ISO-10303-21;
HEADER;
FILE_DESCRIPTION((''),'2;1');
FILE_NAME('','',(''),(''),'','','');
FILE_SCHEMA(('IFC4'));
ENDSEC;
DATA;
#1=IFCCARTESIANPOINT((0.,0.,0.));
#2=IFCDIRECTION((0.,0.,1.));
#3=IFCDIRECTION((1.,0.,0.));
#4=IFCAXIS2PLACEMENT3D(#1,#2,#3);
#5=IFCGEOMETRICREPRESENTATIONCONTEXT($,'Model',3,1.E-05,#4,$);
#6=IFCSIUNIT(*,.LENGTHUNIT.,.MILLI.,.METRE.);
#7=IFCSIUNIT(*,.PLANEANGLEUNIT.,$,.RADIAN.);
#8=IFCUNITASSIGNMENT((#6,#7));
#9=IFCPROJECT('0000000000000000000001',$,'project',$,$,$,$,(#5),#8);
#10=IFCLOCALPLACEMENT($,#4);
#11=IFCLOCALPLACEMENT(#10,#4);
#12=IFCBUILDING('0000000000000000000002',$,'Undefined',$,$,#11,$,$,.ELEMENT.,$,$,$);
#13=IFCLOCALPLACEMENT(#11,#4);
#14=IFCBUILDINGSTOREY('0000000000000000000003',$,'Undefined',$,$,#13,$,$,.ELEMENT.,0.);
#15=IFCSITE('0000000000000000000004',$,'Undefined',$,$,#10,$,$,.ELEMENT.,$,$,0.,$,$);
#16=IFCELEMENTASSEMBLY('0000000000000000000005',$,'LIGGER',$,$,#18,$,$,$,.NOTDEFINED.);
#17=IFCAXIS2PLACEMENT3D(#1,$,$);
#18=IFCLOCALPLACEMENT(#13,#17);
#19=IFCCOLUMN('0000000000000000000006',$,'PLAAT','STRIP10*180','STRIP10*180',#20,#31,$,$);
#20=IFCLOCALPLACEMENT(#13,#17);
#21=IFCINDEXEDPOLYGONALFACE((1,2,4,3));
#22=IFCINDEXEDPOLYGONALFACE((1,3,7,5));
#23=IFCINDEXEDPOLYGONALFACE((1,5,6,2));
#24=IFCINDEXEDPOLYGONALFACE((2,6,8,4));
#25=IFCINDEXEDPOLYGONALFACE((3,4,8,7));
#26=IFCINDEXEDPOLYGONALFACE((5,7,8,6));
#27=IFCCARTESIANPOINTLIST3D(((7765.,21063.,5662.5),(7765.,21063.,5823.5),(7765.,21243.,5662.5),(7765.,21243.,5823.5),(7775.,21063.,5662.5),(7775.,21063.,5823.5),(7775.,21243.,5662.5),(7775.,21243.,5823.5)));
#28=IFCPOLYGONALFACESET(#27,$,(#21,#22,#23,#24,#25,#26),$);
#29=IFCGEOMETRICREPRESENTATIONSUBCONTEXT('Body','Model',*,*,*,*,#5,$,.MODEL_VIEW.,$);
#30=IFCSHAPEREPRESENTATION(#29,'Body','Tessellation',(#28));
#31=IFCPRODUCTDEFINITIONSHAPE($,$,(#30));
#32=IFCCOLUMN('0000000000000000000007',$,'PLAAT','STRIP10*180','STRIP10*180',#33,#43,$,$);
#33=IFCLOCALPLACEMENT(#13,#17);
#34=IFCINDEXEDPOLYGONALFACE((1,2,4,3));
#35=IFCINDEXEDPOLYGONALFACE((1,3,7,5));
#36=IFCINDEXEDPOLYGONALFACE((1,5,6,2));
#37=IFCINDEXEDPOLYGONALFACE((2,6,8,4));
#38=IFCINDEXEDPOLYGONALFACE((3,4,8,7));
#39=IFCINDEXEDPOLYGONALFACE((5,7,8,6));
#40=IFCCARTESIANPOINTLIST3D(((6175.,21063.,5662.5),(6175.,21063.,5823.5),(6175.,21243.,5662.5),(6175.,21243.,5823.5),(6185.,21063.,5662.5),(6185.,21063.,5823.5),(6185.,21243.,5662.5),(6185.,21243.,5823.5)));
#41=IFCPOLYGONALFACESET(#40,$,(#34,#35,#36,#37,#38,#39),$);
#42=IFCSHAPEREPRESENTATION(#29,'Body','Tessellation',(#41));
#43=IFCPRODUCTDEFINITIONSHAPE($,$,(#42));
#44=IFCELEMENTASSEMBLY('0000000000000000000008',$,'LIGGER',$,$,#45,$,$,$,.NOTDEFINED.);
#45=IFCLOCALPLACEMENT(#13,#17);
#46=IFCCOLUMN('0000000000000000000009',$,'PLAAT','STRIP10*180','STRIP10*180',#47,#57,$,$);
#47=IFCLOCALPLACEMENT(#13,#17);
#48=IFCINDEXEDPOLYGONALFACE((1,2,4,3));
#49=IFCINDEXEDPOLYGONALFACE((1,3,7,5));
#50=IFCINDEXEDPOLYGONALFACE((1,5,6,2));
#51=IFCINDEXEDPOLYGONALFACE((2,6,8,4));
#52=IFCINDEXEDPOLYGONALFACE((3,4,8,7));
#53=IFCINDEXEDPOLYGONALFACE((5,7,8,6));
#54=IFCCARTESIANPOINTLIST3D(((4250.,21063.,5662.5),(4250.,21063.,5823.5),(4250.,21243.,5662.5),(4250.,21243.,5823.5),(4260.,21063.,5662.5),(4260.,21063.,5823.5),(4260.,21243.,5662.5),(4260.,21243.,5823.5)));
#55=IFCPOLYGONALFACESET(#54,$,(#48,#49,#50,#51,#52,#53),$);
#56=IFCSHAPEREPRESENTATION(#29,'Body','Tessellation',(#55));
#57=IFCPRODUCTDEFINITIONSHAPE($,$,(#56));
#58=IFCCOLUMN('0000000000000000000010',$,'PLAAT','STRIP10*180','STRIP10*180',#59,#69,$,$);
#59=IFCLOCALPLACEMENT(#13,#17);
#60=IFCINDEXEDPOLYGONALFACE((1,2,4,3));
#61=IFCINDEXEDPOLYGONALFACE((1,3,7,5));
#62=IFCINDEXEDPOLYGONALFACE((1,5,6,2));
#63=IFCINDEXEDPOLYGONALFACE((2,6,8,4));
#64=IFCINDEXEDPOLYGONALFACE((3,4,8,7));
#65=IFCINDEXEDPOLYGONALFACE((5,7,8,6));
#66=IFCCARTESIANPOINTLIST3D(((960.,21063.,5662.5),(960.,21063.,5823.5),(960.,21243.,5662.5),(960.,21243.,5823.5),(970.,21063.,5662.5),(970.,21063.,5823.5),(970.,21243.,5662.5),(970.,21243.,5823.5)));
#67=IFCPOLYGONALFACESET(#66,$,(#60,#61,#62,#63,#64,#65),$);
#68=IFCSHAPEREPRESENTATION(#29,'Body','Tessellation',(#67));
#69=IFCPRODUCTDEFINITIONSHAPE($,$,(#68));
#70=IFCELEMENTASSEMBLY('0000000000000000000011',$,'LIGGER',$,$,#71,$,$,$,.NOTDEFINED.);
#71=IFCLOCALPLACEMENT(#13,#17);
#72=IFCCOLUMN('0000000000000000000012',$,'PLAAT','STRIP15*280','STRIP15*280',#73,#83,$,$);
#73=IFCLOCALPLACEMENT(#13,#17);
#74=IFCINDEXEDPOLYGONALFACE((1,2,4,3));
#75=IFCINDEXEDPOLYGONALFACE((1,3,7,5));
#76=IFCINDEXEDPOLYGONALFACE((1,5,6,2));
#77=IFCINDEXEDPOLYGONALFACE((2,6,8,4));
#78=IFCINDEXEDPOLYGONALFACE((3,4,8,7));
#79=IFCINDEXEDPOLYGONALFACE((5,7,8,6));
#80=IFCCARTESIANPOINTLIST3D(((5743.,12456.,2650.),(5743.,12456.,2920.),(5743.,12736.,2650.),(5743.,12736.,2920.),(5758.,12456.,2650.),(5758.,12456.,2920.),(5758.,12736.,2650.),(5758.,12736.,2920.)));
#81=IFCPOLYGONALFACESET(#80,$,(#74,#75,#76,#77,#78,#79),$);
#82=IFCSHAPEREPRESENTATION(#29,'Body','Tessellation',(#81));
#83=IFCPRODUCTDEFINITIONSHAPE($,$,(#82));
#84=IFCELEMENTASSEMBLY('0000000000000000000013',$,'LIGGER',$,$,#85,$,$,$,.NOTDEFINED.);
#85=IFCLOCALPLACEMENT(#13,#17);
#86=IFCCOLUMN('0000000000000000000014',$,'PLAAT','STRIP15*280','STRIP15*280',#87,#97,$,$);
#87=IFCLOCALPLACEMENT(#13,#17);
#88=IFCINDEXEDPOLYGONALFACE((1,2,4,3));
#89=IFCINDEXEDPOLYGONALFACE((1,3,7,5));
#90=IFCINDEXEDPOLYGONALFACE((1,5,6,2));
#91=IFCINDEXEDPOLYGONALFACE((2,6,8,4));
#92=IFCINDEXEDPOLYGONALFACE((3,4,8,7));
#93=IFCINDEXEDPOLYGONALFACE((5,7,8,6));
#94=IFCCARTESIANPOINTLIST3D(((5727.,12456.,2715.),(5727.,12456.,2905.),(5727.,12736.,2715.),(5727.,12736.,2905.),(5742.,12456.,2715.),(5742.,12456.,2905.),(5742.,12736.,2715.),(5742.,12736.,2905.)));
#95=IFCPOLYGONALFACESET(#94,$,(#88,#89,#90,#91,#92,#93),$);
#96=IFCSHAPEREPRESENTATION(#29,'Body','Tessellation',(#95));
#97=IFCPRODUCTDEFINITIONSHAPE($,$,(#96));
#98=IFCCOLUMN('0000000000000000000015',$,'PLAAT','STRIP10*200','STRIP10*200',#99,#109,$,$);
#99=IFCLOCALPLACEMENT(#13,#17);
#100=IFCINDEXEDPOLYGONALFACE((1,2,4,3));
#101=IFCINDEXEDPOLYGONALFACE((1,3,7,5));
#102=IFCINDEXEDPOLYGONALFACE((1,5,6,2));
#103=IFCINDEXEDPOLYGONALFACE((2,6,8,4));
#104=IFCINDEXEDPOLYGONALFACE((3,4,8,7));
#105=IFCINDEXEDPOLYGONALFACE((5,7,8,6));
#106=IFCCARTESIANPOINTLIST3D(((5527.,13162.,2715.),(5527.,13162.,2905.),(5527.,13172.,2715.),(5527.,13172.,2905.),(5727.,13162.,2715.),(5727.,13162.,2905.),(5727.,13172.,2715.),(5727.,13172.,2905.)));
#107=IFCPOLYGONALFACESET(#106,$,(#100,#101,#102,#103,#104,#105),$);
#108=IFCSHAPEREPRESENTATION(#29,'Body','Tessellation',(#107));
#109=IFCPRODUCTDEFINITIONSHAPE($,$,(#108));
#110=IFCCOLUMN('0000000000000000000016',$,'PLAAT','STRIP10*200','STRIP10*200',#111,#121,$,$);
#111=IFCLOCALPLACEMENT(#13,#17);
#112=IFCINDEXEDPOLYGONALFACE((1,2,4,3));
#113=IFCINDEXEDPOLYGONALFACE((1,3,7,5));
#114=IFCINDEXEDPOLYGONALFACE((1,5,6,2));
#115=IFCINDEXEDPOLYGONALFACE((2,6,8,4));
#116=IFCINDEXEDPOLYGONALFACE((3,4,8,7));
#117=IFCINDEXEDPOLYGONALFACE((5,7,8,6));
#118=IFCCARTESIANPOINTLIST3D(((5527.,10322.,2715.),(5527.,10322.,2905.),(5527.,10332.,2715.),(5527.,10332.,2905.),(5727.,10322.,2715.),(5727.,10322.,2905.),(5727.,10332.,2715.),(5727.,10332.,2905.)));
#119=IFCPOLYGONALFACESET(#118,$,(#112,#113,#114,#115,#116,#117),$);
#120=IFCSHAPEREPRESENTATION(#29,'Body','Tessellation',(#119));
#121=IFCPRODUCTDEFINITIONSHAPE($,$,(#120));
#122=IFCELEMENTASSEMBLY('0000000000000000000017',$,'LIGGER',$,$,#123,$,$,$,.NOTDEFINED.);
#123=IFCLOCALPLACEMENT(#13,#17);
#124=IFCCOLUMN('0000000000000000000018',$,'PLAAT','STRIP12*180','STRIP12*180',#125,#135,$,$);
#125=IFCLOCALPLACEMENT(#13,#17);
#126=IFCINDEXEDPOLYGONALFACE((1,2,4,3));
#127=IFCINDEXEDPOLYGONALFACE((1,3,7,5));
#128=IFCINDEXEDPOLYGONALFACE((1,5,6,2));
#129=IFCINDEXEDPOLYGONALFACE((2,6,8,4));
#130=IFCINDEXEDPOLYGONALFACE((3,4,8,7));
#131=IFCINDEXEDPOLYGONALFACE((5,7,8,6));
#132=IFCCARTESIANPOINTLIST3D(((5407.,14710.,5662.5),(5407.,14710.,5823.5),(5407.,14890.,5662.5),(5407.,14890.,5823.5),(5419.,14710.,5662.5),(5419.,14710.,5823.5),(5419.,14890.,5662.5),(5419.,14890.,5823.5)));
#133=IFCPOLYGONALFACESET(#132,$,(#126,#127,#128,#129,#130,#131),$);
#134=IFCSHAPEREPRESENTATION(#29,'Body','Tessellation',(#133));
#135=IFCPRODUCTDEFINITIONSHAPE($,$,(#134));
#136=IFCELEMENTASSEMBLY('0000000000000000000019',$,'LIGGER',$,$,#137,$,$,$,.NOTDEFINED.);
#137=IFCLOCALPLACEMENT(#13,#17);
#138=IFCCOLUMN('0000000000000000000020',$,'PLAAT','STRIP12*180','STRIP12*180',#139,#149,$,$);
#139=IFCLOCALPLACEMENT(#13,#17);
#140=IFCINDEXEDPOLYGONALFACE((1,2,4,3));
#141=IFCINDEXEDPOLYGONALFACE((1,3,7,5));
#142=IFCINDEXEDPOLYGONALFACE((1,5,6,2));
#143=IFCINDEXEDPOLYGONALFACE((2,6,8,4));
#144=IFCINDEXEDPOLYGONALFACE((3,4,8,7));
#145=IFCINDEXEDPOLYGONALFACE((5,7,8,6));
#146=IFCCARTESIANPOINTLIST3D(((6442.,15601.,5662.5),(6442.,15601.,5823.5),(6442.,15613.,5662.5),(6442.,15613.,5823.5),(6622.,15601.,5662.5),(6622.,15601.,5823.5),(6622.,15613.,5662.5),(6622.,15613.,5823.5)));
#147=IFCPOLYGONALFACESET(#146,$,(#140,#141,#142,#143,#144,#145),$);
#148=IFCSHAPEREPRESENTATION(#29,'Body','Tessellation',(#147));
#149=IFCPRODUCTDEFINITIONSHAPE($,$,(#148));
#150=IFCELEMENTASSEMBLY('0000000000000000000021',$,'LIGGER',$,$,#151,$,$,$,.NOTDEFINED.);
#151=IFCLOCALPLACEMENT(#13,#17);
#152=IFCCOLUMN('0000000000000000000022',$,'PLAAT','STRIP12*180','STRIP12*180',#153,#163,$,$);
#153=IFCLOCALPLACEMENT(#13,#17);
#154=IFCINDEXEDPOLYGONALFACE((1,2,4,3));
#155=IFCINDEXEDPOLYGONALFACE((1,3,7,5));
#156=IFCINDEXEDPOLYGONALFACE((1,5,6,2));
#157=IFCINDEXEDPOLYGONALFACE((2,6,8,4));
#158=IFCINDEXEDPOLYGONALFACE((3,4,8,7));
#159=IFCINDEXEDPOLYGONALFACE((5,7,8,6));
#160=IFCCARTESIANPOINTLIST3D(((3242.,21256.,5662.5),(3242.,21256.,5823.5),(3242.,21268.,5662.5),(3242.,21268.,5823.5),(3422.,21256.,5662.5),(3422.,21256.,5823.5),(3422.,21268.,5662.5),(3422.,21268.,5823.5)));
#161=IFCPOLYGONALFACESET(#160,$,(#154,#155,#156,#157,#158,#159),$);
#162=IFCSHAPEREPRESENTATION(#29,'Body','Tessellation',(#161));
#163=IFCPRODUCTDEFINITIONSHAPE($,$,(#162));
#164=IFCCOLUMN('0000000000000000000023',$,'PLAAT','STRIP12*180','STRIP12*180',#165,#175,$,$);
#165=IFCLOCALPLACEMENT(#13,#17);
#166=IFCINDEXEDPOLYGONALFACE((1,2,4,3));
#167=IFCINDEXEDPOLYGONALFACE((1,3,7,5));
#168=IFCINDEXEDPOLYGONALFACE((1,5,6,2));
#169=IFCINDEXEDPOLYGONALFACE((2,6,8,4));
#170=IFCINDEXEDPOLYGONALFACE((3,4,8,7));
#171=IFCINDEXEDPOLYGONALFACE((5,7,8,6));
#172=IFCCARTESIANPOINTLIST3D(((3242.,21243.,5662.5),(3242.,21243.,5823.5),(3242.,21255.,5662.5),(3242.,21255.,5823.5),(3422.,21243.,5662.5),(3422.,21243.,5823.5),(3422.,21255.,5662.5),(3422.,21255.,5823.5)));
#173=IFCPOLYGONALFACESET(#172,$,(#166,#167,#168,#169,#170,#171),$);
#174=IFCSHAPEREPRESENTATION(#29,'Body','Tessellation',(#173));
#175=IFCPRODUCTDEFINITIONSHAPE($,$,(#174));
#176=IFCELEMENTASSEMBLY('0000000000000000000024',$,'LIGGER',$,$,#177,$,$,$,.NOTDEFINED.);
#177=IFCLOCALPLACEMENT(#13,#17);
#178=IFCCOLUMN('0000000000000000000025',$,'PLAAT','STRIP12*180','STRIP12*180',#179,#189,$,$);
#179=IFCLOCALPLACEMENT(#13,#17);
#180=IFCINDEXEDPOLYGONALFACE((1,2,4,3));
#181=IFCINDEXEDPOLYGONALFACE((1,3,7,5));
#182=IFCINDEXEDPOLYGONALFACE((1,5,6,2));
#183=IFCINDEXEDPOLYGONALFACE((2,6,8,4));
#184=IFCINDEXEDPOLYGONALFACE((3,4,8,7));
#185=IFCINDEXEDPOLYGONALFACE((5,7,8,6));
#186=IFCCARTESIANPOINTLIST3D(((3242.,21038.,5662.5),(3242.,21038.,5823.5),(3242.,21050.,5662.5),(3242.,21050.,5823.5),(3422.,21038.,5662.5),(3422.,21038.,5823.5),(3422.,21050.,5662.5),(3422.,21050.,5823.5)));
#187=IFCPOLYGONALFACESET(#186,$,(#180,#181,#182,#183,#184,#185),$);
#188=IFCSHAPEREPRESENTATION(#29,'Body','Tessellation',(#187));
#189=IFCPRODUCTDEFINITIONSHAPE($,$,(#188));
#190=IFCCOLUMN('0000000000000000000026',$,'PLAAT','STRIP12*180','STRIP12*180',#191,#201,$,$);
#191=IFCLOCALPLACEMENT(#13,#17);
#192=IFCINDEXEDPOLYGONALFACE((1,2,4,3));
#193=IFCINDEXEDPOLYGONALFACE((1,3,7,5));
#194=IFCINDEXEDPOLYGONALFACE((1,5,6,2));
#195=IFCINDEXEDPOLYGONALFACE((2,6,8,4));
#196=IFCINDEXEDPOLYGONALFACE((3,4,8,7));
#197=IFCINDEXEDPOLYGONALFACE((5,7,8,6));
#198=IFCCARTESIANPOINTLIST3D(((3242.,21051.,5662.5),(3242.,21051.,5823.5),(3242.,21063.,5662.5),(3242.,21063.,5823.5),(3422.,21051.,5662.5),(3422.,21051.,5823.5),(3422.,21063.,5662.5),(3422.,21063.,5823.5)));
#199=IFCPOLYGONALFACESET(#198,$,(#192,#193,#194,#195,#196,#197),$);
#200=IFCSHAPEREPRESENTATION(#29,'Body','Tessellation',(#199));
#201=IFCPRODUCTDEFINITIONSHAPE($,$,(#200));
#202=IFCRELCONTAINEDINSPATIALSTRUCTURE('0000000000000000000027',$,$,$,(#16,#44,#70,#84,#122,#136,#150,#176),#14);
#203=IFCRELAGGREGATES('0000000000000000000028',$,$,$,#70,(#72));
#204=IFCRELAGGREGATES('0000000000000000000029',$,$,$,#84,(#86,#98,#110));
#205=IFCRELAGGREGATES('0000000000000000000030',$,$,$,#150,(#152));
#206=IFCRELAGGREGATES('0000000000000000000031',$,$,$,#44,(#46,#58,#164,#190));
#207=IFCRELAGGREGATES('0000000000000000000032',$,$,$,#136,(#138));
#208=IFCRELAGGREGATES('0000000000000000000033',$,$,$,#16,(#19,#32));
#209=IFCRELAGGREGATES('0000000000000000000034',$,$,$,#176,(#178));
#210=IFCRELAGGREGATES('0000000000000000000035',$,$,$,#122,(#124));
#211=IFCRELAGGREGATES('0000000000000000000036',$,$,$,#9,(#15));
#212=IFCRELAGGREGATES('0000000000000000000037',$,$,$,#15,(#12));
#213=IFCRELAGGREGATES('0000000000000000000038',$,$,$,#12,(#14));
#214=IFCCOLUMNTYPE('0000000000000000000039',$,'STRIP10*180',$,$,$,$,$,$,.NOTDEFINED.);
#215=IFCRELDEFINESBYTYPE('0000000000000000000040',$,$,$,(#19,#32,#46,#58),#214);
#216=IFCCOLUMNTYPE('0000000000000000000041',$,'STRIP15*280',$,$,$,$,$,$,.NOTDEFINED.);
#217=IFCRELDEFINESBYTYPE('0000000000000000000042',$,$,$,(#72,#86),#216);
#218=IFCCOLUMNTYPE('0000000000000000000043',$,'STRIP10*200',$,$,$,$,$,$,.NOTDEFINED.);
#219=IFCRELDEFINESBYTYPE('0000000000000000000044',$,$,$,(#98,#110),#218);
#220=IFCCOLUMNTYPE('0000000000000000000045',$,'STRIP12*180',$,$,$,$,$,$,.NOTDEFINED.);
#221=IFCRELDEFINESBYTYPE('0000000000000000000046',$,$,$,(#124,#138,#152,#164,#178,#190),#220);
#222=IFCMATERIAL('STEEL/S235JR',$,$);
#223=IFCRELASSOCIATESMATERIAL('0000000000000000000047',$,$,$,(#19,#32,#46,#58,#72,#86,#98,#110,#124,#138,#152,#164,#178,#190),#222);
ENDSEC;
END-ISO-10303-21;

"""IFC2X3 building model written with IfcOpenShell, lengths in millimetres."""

from ifc_helpers import new_model, si_unit, frame, origin_with_axes, origin_2d_with_axis, place, context, subcontext, project, spatial, rectangle, extrude, material, type_object, element, aggregate, save


model = new_model("IFC2X3")

# Units and contexts
model_context = context("Model", 3, precision=1e-05, world=origin_with_axes())
body_context = subcontext(model_context, "Body", "Model", "MODEL_VIEW")
ifc_project = project(units=[si_unit("LENGTHUNIT", "METRE", prefix="MILLI"), si_unit("PLANEANGLEUNIT", "RADIAN")], contexts=[model_context])

# Site, building, storey
site_placement = place(None, origin_with_axes())
site = spatial("IfcSite", under=ifc_project, at=site_placement, Name="Undefined", CompositionType="ELEMENT", RefElevation=0.0)
building_placement = place(site_placement, origin_with_axes())
building = spatial("IfcBuilding", under=site, at=building_placement, Name="Undefined", CompositionType="ELEMENT")
storey_placement = place(building_placement, origin_with_axes())
storey = spatial("IfcBuildingStorey", under=building, at=storey_placement, Name="Undefined", CompositionType="ELEMENT", Elevation=0.0)

# Element assemblies, columns
assembly_1_placement = place(storey_placement, frame((7775.0, 21153.0, 5743.0), z_axis=(0.0, 0.0, 1.0), x_axis=(-1.0, 0.0, 0.0)))
assembly_1 = element("IfcElementAssembly", 1, at=assembly_1_placement, inside=storey, Name="LIGGER", PredefinedType="NOTDEFINED")
ifc_material = material(Name="STEEL/S235JR")
column_type_1 = type_object("IfcColumnType", Name="STRIP10*180", PredefinedType="NOTDEFINED")
column_1_placement = place(storey_placement, frame((7770.0, 21153.0, 5662.5), z_axis=(0.0, 0.0, 1.0), x_axis=(1.0, 0.0, 0.0)))
column_1 = element("IfcColumn", 2, at=column_1_placement, type_object=column_type_1, material=ifc_material, Name="PLAAT", Description="STRIP10*180", ObjectType="STRIP10*180", context=body_context, shape_type="SweptSolid", body=[
    extrude(rectangle(XDim=10.0, YDim=180.0, at=origin_2d_with_axis()), frame((0.0, 0.0, 161.0), z_axis=(0.0, 0.0, -1.0), x_axis=(-1.0, 0.0, 0.0)), (0.0, 0.0, 1.0), 161.0),
])
column_2_placement = place(storey_placement, frame((6180.0, 21153.0, 5662.5), z_axis=(0.0, 0.0, 1.0), x_axis=(1.0, 0.0, 0.0)))
column_2 = element("IfcColumn", 3, at=column_2_placement, type_object=column_type_1, material=ifc_material, Name="PLAAT", Description="STRIP10*180", ObjectType="STRIP10*180", context=body_context, shape_type="SweptSolid", body=[
    extrude(rectangle(XDim=10.0, YDim=180.0, at=origin_2d_with_axis()), frame((0.0, 0.0, 161.0), z_axis=(0.0, 0.0, -1.0), x_axis=(1.0, 0.0, 0.0)), (0.0, 0.0, 1.0), 161.0),
])
assembly_2_placement = place(storey_placement, frame((960.0, 21153.0, 5743.0), z_axis=(0.0, 0.0, 1.0), x_axis=(1.0, 0.0, 0.0)))
assembly_2 = element("IfcElementAssembly", 4, at=assembly_2_placement, inside=storey, Name="LIGGER", PredefinedType="NOTDEFINED")
column_3_placement = place(storey_placement, frame((4255.0, 21153.0, 5662.5), z_axis=(0.0, 0.0, 1.0), x_axis=(1.0, 0.0, 0.0)))
column_3 = element("IfcColumn", 5, at=column_3_placement, type_object=column_type_1, material=ifc_material, Name="PLAAT", Description="STRIP10*180", ObjectType="STRIP10*180", context=body_context, shape_type="SweptSolid", body=[
    extrude(rectangle(XDim=10.0, YDim=180.0, at=origin_2d_with_axis()), frame((0.0, 0.0, 161.0), z_axis=(0.0, 0.0, -1.0), x_axis=(-1.0, 0.0, 0.0)), (0.0, 0.0, 1.0), 161.0),
])
column_4_placement = place(storey_placement, frame((965.0, 21153.0, 5662.5), z_axis=(0.0, 0.0, 1.0), x_axis=(1.0, 0.0, 0.0)))
column_4 = element("IfcColumn", 6, at=column_4_placement, type_object=column_type_1, material=ifc_material, Name="PLAAT", Description="STRIP10*180", ObjectType="STRIP10*180", context=body_context, shape_type="SweptSolid", body=[
    extrude(rectangle(XDim=10.0, YDim=180.0, at=origin_2d_with_axis()), frame((0.0, 0.0, 161.0), z_axis=(0.0, 0.0, -1.0), x_axis=(1.0, 0.0, 0.0)), (0.0, 0.0, 1.0), 161.0),
])

# Element assembly, column
assembly_3_placement = place(storey_placement, frame((5727.0, 12596.0, 2785.0), z_axis=(0.0, 0.0, 1.0), x_axis=(1.0, 0.0, 0.0)))
assembly_3 = element("IfcElementAssembly", 7, at=assembly_3_placement, inside=storey, Name="LIGGER", PredefinedType="NOTDEFINED")
column_type_2 = type_object("IfcColumnType", Name="STRIP15*280", PredefinedType="NOTDEFINED")
column_5_placement = place(storey_placement, frame((5750.5, 12596.0, 2650.0), z_axis=(0.0, 0.0, 1.0), x_axis=(1.0, 0.0, 0.0)))
column_5 = element("IfcColumn", 8, at=column_5_placement, type_object=column_type_2, material=ifc_material, Name="PLAAT", Description="STRIP15*280", ObjectType="STRIP15*280", context=body_context, shape_type="SweptSolid", body=[
    extrude(rectangle(XDim=15.0, YDim=280.0, at=origin_2d_with_axis()), frame((0.0, 0.0, 270.0), z_axis=(0.0, 0.0, -1.0), x_axis=(1.0, 0.0, 0.0)), (0.0, 0.0, 1.0), 270.0),
])
aggregate(assembly_3, [column_5])

# Element assembly, columns
assembly_4_placement = place(storey_placement, frame((5627.0, 10322.0, 2810.0), z_axis=(0.0, 0.0, 1.0), x_axis=(0.0, 1.0, 0.0)))
assembly_4 = element("IfcElementAssembly", 9, at=assembly_4_placement, inside=storey, Name="LIGGER", PredefinedType="NOTDEFINED")
column_6_placement = place(storey_placement, frame((5734.5, 12596.0, 2715.0), z_axis=(0.0, 0.0, 1.0), x_axis=(1.0, 0.0, 0.0)))
column_6 = element("IfcColumn", 10, at=column_6_placement, type_object=column_type_2, material=ifc_material, Name="PLAAT", Description="STRIP15*280", ObjectType="STRIP15*280", context=body_context, shape_type="SweptSolid", body=[
    extrude(rectangle(XDim=15.0, YDim=280.0, at=origin_2d_with_axis()), frame((0.0, 0.0, 190.0), z_axis=(0.0, 0.0, -1.0), x_axis=(1.0, 0.0, 0.0)), (0.0, 0.0, 1.0), 190.0),
])
column_type_3 = type_object("IfcColumnType", Name="STRIP10*200", PredefinedType="NOTDEFINED")
column_7_placement = place(storey_placement, frame((5627.0, 13167.0, 2715.0), z_axis=(0.0, 0.0, 1.0), x_axis=(1.0, 0.0, 0.0)))
column_7 = element("IfcColumn", 11, at=column_7_placement, type_object=column_type_3, material=ifc_material, Name="PLAAT", Description="STRIP10*200", ObjectType="STRIP10*200", context=body_context, shape_type="SweptSolid", body=[
    extrude(rectangle(XDim=10.0, YDim=200.0, at=origin_2d_with_axis()), frame((0.0, 0.0, 190.0), z_axis=(0.0, 0.0, -1.0), x_axis=(0.0, -1.0, 0.0)), (0.0, 0.0, 1.0), 190.0),
])
column_8_placement = place(storey_placement, frame((5627.0, 10327.0, 2715.0), z_axis=(0.0, 0.0, 1.0), x_axis=(1.0, 0.0, 0.0)))
column_8 = element("IfcColumn", 12, at=column_8_placement, type_object=column_type_3, material=ifc_material, Name="PLAAT", Description="STRIP10*200", ObjectType="STRIP10*200", context=body_context, shape_type="SweptSolid", body=[
    extrude(rectangle(XDim=10.0, YDim=200.0, at=origin_2d_with_axis()), frame((0.0, 0.0, 190.0), z_axis=(0.0, 0.0, -1.0), x_axis=(0.0, 1.0, 0.0)), (0.0, 0.0, 1.0), 190.0),
])
aggregate(assembly_4, [column_6, column_7, column_8])

# Element assemblies, columns
assembly_5_placement = place(storey_placement, frame((810.1, 14800.0, 5743.0), z_axis=(0.0, 0.0, 1.0), x_axis=(1.0, 0.0, 0.0)))
assembly_5 = element("IfcElementAssembly", 13, at=assembly_5_placement, inside=storey, Name="LIGGER", PredefinedType="NOTDEFINED")
column_type_4 = type_object("IfcColumnType", Name="STRIP12*180", PredefinedType="NOTDEFINED")
column_9_placement = place(storey_placement, frame((5413.0, 14800.0, 5662.5), z_axis=(0.0, 0.0, 1.0), x_axis=(1.0, 0.0, 0.0)))
column_9 = element("IfcColumn", 14, at=column_9_placement, type_object=column_type_4, material=ifc_material, Name="PLAAT", Description="STRIP12*180", ObjectType="STRIP12*180", context=body_context, shape_type="SweptSolid", body=[
    extrude(rectangle(XDim=12.0, YDim=180.0, at=origin_2d_with_axis()), frame((0.0, 0.0, 161.0), z_axis=(0.0, 0.0, -1.0), x_axis=(-1.0, 0.0, 0.0)), (0.0, 0.0, 1.0), 161.0),
])
assembly_6_placement = place(storey_placement, frame((6532.0, 21062.1, 5743.0), z_axis=(0.0, 0.0, 1.0), x_axis=(0.0, -1.0, 0.0)))
assembly_6 = element("IfcElementAssembly", 15, at=assembly_6_placement, inside=storey, Name="LIGGER", PredefinedType="NOTDEFINED")
column_10_placement = place(storey_placement, frame((6532.0, 15607.0, 5662.5), z_axis=(0.0, 0.0, 1.0), x_axis=(1.0, 0.0, 0.0)))
column_10 = element("IfcColumn", 16, at=column_10_placement, type_object=column_type_4, material=ifc_material, Name="PLAAT", Description="STRIP12*180", ObjectType="STRIP12*180", context=body_context, shape_type="SweptSolid", body=[
    extrude(rectangle(XDim=12.0, YDim=180.0, at=origin_2d_with_axis()), frame((0.0, 0.0, 161.0), z_axis=(0.0, 0.0, -1.0), x_axis=(0.0, 1.0, 0.0)), (0.0, 0.0, 1.0), 161.0),
])
assembly_7_placement = place(storey_placement, frame((3332.0, 21875.0, 5743.0), z_axis=(0.0, 0.0, 1.0), x_axis=(0.0, -1.0, 0.0)))
assembly_7 = element("IfcElementAssembly", 17, at=assembly_7_placement, inside=storey, Name="LIGGER", PredefinedType="NOTDEFINED")
column_11_placement = place(storey_placement, frame((3332.0, 21262.0, 5662.5), z_axis=(0.0, 0.0, 1.0), x_axis=(1.0, 0.0, 0.0)))
column_11 = element("IfcColumn", 18, at=column_11_placement, type_object=column_type_4, material=ifc_material, Name="PLAAT", Description="STRIP12*180", ObjectType="STRIP12*180", context=body_context, shape_type="SweptSolid", body=[
    extrude(rectangle(XDim=12.0, YDim=180.0, at=origin_2d_with_axis()), frame((0.0, 0.0, 161.0), z_axis=(0.0, 0.0, -1.0), x_axis=(0.0, 1.0, 0.0)), (0.0, 0.0, 1.0), 161.0),
])
aggregate(assembly_7, [column_11])

# Column
column_12_placement = place(storey_placement, frame((3332.0, 21249.0, 5662.5), z_axis=(0.0, 0.0, 1.0), x_axis=(1.0, 0.0, 0.0)))
column_12 = element("IfcColumn", 19, at=column_12_placement, type_object=column_type_4, material=ifc_material, Name="PLAAT", Description="STRIP12*180", ObjectType="STRIP12*180", context=body_context, shape_type="SweptSolid", body=[
    extrude(rectangle(XDim=12.0, YDim=180.0, at=origin_2d_with_axis()), frame((0.0, 0.0, 161.0), z_axis=(0.0, 0.0, -1.0), x_axis=(0.0, 1.0, 0.0)), (0.0, 0.0, 1.0), 161.0),
])

# Element assembly, column
assembly_8_placement = place(storey_placement, frame((3332.0, 21063.0, 5743.0), z_axis=(0.0, 0.0, 1.0), x_axis=(0.0, -1.0, 0.0)))
assembly_8 = element("IfcElementAssembly", 20, at=assembly_8_placement, inside=storey, Name="LIGGER", PredefinedType="NOTDEFINED")
column_13_placement = place(storey_placement, frame((3332.0, 21044.0, 5662.5), z_axis=(0.0, 0.0, 1.0), x_axis=(1.0, 0.0, 0.0)))
column_13 = element("IfcColumn", 21, at=column_13_placement, type_object=column_type_4, material=ifc_material, Name="PLAAT", Description="STRIP12*180", ObjectType="STRIP12*180", context=body_context, shape_type="SweptSolid", body=[
    extrude(rectangle(XDim=12.0, YDim=180.0, at=origin_2d_with_axis()), frame((0.0, 0.0, 161.0), z_axis=(0.0, 0.0, -1.0), x_axis=(0.0, -1.0, 0.0)), (0.0, 0.0, 1.0), 161.0),
])

# Column
column_14_placement = place(storey_placement, frame((3332.0, 21057.0, 5662.5), z_axis=(0.0, 0.0, 1.0), x_axis=(1.0, 0.0, 0.0)))
column_14 = element("IfcColumn", 22, at=column_14_placement, type_object=column_type_4, material=ifc_material, Name="PLAAT", Description="STRIP12*180", ObjectType="STRIP12*180", context=body_context, shape_type="SweptSolid", body=[
    extrude(rectangle(XDim=12.0, YDim=180.0, at=origin_2d_with_axis()), frame((0.0, 0.0, 161.0), z_axis=(0.0, 0.0, -1.0), x_axis=(0.0, -1.0, 0.0)), (0.0, 0.0, 1.0), 161.0),
])
aggregate(assembly_2, [column_3, column_4, column_12, column_14])

aggregate(assembly_6, [column_10])
aggregate(assembly_1, [column_1, column_2])
aggregate(assembly_8, [column_13])

aggregate(assembly_5, [column_9])

save(model, "model.ifc")
